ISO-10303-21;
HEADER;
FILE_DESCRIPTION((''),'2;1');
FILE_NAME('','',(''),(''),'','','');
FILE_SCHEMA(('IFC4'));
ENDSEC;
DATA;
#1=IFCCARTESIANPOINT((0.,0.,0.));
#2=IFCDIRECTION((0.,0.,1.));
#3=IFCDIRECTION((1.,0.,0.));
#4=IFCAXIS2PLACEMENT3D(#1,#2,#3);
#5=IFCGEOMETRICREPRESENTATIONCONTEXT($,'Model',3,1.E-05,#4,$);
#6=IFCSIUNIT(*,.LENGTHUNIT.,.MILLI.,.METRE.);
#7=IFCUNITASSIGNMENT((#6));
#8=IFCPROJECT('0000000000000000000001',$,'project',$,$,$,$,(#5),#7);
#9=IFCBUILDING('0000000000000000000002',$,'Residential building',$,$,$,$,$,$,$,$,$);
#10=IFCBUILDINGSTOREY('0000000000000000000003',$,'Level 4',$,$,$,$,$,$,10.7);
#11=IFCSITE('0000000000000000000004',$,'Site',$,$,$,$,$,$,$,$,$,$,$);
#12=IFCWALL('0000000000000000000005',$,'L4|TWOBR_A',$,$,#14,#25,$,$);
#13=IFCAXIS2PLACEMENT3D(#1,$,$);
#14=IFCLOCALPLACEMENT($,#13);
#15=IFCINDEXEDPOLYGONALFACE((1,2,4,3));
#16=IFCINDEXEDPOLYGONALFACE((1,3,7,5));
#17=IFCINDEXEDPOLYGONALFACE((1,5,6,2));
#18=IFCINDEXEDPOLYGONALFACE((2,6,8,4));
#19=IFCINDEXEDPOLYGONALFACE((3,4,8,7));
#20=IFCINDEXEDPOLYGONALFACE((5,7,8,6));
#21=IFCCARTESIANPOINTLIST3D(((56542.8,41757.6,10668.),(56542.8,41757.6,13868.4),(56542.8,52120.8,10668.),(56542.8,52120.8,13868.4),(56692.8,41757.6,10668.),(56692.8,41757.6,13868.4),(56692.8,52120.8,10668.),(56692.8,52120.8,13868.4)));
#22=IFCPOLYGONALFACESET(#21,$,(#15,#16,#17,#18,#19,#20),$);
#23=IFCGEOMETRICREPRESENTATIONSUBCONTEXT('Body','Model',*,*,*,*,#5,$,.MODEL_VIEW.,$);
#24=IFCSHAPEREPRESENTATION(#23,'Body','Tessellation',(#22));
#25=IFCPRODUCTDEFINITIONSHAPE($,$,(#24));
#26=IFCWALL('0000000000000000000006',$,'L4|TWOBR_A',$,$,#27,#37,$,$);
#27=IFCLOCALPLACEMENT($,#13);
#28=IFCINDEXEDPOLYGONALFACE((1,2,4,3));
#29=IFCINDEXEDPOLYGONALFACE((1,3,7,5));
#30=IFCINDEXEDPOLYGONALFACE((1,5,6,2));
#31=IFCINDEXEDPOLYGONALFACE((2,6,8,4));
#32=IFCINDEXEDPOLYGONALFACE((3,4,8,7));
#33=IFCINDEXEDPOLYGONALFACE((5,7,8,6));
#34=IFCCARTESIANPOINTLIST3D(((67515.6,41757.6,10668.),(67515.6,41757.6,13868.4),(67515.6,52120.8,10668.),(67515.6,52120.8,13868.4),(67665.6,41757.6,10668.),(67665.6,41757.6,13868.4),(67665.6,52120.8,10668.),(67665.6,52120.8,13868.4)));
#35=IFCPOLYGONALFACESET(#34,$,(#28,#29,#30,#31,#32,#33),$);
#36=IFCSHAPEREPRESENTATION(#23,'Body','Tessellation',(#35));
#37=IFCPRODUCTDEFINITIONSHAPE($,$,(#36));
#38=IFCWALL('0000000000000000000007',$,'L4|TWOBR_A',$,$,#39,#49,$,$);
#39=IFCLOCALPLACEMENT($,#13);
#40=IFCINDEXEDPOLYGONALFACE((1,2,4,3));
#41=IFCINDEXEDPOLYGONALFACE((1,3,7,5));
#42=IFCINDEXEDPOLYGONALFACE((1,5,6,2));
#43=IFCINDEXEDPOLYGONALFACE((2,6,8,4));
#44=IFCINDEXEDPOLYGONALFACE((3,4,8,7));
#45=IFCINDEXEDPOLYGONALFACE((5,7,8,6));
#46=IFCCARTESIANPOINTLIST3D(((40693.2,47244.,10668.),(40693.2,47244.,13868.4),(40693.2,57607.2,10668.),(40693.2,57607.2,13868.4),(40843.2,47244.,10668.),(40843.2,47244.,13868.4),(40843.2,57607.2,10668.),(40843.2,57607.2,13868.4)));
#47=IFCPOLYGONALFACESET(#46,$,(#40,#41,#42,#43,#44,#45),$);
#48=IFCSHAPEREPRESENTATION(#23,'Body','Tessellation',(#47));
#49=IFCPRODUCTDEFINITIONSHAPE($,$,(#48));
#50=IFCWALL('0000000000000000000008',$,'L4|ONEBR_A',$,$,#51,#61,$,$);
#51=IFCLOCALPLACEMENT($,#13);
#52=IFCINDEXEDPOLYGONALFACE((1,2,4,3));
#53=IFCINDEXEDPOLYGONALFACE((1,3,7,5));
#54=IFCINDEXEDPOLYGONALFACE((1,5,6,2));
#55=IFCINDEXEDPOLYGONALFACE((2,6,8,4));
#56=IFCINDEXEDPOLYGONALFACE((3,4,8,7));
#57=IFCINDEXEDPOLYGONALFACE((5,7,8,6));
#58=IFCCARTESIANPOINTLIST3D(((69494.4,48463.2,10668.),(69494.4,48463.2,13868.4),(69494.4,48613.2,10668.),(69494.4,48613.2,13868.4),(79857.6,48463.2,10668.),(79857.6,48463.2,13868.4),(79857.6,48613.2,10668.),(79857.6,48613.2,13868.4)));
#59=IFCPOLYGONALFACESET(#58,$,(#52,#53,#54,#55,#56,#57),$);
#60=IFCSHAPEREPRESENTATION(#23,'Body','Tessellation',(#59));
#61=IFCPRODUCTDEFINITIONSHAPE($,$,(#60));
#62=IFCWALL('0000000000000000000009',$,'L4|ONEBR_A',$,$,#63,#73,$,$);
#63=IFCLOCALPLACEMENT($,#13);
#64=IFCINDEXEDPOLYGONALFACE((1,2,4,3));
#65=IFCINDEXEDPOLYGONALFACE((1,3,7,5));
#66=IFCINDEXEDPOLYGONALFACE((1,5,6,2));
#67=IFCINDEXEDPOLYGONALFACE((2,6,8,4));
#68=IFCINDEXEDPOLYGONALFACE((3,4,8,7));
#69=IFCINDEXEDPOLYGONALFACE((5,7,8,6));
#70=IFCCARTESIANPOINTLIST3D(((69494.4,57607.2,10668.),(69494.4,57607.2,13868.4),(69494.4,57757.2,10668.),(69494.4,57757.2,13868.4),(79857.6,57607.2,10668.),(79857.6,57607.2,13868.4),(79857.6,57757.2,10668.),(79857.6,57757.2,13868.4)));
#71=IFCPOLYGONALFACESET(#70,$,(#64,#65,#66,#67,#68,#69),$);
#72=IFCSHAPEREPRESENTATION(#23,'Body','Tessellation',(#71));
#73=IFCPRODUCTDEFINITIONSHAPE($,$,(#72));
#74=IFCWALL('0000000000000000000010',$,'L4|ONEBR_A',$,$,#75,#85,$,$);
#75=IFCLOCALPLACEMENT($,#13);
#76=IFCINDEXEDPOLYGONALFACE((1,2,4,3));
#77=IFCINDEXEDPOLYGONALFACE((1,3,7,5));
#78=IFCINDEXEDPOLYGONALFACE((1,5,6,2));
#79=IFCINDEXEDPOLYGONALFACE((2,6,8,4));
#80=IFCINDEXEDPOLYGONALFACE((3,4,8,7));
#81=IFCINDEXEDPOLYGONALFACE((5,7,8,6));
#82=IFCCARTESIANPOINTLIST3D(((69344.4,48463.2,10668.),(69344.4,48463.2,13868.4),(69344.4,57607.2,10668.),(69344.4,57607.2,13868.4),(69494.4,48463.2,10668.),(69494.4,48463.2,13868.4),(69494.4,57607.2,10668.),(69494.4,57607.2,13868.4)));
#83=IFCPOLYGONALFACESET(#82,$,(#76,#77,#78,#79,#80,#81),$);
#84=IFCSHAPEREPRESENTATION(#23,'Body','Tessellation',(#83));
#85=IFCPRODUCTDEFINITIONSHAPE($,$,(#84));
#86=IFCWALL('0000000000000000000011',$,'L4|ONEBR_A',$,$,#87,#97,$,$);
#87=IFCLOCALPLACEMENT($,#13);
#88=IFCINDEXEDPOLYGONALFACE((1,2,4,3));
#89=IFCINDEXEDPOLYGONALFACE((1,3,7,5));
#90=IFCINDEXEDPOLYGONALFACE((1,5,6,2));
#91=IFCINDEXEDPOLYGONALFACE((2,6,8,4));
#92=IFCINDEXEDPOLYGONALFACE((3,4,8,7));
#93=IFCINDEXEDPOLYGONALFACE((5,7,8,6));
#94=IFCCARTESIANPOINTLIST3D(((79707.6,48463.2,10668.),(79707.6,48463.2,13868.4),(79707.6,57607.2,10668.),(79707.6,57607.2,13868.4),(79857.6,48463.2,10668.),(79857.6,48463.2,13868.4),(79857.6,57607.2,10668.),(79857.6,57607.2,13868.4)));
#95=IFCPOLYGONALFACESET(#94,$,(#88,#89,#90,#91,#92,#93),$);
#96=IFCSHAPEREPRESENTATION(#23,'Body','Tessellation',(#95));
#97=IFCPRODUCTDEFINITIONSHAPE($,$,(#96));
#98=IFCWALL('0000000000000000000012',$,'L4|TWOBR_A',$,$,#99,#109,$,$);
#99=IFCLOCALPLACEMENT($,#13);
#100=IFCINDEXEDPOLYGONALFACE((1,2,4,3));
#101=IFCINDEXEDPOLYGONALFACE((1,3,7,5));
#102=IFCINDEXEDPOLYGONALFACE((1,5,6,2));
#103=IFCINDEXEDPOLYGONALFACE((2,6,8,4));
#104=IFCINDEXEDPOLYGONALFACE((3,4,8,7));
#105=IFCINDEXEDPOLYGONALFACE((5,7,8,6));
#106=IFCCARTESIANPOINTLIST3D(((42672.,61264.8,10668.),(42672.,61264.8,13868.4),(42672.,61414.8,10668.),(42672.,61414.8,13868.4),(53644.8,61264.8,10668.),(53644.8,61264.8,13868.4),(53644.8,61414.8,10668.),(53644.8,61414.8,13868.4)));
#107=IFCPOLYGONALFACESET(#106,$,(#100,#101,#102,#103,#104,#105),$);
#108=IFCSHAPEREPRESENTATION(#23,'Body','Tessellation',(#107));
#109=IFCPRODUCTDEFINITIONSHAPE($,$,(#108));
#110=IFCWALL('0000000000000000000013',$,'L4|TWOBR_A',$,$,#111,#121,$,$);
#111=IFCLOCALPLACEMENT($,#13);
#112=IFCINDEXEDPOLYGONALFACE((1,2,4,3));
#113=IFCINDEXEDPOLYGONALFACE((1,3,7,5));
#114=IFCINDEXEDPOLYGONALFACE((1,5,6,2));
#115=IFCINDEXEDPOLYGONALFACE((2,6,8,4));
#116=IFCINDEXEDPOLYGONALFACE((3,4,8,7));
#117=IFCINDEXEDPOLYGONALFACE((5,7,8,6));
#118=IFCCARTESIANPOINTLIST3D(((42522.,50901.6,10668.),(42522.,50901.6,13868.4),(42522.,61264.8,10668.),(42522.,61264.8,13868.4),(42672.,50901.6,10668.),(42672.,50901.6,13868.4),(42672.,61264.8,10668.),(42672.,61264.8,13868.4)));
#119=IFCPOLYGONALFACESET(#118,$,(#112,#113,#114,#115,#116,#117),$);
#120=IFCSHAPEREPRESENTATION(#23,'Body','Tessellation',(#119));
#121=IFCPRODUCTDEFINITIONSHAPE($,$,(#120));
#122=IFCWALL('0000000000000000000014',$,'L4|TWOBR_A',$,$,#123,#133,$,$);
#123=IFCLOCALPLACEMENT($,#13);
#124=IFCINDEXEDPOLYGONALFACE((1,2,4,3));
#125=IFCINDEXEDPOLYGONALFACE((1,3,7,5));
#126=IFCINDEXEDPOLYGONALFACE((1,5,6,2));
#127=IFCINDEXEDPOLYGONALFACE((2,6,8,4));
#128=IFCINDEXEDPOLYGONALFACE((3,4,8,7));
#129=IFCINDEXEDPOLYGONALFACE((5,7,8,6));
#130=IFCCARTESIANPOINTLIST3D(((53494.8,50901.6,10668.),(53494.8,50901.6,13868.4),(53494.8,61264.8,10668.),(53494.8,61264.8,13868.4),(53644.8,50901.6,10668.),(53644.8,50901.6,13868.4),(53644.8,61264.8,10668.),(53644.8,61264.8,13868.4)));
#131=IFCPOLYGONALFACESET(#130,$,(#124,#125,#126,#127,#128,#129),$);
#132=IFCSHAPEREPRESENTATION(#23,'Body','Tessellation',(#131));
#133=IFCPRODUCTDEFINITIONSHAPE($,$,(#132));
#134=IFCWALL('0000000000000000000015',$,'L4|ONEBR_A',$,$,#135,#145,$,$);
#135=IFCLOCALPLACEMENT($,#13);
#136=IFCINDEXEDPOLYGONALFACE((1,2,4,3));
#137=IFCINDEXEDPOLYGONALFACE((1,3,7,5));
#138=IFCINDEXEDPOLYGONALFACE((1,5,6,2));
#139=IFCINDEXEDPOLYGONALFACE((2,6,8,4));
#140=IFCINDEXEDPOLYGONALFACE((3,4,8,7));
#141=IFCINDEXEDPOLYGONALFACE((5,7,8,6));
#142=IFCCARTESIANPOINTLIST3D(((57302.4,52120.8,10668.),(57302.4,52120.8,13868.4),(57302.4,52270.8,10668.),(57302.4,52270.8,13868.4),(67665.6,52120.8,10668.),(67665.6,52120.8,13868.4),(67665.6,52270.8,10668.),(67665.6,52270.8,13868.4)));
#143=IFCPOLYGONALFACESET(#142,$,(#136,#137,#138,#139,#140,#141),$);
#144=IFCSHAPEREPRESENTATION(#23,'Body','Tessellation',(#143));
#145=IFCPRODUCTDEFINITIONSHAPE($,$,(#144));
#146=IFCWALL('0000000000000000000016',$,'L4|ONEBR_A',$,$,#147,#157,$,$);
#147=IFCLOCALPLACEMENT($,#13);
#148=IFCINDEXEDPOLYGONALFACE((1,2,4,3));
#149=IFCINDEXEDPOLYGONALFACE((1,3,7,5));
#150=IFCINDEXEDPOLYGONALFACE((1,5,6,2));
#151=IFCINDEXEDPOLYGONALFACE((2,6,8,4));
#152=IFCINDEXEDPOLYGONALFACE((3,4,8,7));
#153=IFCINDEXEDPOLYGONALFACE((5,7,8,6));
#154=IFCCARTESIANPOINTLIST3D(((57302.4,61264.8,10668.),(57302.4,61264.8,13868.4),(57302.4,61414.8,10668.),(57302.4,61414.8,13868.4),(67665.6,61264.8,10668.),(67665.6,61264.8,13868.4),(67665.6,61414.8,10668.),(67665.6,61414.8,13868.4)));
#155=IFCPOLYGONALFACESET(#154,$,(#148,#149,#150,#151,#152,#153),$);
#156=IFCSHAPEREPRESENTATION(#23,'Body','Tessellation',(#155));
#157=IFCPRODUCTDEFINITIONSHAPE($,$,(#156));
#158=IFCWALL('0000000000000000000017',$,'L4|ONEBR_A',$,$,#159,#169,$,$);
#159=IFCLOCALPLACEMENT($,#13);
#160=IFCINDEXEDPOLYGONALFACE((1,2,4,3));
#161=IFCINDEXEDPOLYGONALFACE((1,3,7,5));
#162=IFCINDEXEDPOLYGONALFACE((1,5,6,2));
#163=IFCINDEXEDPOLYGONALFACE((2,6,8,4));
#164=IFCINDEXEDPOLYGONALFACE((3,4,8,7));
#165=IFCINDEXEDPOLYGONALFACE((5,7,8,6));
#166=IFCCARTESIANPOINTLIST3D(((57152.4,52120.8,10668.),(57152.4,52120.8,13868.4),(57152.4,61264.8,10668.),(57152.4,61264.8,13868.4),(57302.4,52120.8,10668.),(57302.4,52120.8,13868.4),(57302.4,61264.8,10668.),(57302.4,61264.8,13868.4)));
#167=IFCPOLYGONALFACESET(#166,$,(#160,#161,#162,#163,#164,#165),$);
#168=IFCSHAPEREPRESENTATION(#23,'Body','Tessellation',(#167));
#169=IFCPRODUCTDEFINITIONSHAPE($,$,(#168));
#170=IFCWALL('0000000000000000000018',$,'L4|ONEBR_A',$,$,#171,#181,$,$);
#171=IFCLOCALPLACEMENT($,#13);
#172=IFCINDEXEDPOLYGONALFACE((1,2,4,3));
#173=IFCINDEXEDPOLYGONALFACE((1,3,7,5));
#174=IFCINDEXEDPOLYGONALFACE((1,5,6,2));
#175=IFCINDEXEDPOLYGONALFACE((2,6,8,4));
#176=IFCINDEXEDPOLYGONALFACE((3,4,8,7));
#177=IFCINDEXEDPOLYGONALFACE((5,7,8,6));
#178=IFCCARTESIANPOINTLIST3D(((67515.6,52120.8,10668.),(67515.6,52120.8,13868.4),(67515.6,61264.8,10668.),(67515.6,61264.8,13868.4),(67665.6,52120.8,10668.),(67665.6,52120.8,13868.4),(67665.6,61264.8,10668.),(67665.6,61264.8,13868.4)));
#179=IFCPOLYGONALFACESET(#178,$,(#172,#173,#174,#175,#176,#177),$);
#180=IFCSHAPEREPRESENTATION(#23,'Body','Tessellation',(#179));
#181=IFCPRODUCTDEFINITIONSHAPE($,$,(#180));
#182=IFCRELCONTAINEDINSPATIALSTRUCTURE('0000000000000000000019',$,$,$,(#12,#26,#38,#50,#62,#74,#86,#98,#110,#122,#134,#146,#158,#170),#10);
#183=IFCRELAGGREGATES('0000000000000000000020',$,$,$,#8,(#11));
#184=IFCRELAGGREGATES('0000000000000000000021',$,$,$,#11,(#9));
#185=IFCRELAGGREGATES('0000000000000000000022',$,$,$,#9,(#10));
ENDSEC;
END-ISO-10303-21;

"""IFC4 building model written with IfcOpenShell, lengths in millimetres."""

from ifc_helpers import new_model, si_unit, frame, origin_with_axes, place, context, subcontext, project, spatial, indexed_curve, outline, extrude, element, save


model = new_model("IFC4")

# Units and contexts
model_context = context("Model", 3, precision=1e-05, world=origin_with_axes())
body_context = subcontext(model_context, "Body", "Model", "MODEL_VIEW")
ifc_project = project(units=[si_unit("LENGTHUNIT", "METRE", prefix="MILLI")], contexts=[model_context])

# Site, building, storey
site = spatial("IfcSite", under=ifc_project, Name="Site")
building = spatial("IfcBuilding", under=site, Name="Residential building")
storey = spatial("IfcBuildingStorey", under=building, Name="Level 4", Elevation=10.7)

# Walls
for number, where, z_axis, x_axis, name in (
    (1, (56692.8, 41757.6, 10668.0), (0.0, 0.0, 1.0), (0.0, 1.0, 0.0), "L4|TWOBR_A"),
    (2, (67665.6, 41757.6, 10668.0), (0.0, 0.0, 1.0), (0.0, 1.0, 0.0), "L4|TWOBR_A"),
    (3, (40843.2, 47244.0, 10668.0), (0.0, 0.0, 1.0), (0.0, 1.0, 0.0), "L4|TWOBR_A"),
    (4, (69494.4, 48463.2, 10668.0), (0.0, 0.0, 1.0), (1.0, 0.0, 0.0), "L4|ONEBR_A"),
    (5, (69494.4, 57607.2, 10668.0), (0.0, 0.0, 1.0), (1.0, 0.0, 0.0), "L4|ONEBR_A"),
):
    element("IfcWall", number, at=place(None, frame(where, z_axis=z_axis, x_axis=x_axis)), inside=storey, Name=name, context=body_context, shape_type="SweptSolid", body=[
        extrude(outline(indexed_curve([(0.0, 0.0), (0.0, 150.0), (10363.2, 150.0), (10363.2, 0.0), (0.0, 0.0)], self_intersect=False)), origin_with_axes(), (0.0, 0.0, 1.0), 3200.4),
    ])
for number, where, z_axis, x_axis, name in (
    (6, (69494.4, 48463.2, 10668.0), (0.0, 0.0, 1.0), (0.0, 1.0, 0.0), "L4|ONEBR_A"),
    (7, (79857.6, 48463.2, 10668.0), (0.0, 0.0, 1.0), (0.0, 1.0, 0.0), "L4|ONEBR_A"),
):
    element("IfcWall", number, at=place(None, frame(where, z_axis=z_axis, x_axis=x_axis)), inside=storey, Name=name, context=body_context, shape_type="SweptSolid", body=[
        extrude(outline(indexed_curve([(0.0, 0.0), (0.0, 150.0), (9144.0, 150.0), (9144.0, 0.0), (0.0, 0.0)], self_intersect=False)), origin_with_axes(), (0.0, 0.0, 1.0), 3200.4),
    ])
for number, where, z_axis, x_axis, name in (
    (8, (42672.0, 61264.8, 10668.0), (0.0, 0.0, 1.0), (1.0, 0.0, 0.0), "L4|TWOBR_A"),
):
    element("IfcWall", number, at=place(None, frame(where, z_axis=z_axis, x_axis=x_axis)), inside=storey, Name=name, context=body_context, shape_type="SweptSolid", body=[
        extrude(outline(indexed_curve([(0.0, 0.0), (0.0, 150.0), (10972.8, 150.0), (10972.8, 0.0), (0.0, 0.0)], self_intersect=False)), origin_with_axes(), (0.0, 0.0, 1.0), 3200.4),
    ])
for number, where, z_axis, x_axis, name in (
    (9, (42672.0, 50901.6, 10668.0), (0.0, 0.0, 1.0), (0.0, 1.0, 0.0), "L4|TWOBR_A"),
    (10, (53644.8, 50901.6, 10668.0), (0.0, 0.0, 1.0), (0.0, 1.0, 0.0), "L4|TWOBR_A"),
    (11, (57302.4, 52120.8, 10668.0), (0.0, 0.0, 1.0), (1.0, 0.0, 0.0), "L4|ONEBR_A"),
    (12, (57302.4, 61264.8, 10668.0), (0.0, 0.0, 1.0), (1.0, 0.0, 0.0), "L4|ONEBR_A"),
):
    element("IfcWall", number, at=place(None, frame(where, z_axis=z_axis, x_axis=x_axis)), inside=storey, Name=name, context=body_context, shape_type="SweptSolid", body=[
        extrude(outline(indexed_curve([(0.0, 0.0), (0.0, 150.0), (10363.2, 150.0), (10363.2, 0.0), (0.0, 0.0)], self_intersect=False)), origin_with_axes(), (0.0, 0.0, 1.0), 3200.4),
    ])
for number, where, z_axis, x_axis, name in (
    (13, (57302.4, 52120.8, 10668.0), (0.0, 0.0, 1.0), (0.0, 1.0, 0.0), "L4|ONEBR_A"),
    (14, (67665.6, 52120.8, 10668.0), (0.0, 0.0, 1.0), (0.0, 1.0, 0.0), "L4|ONEBR_A"),
):
    element("IfcWall", number, at=place(None, frame(where, z_axis=z_axis, x_axis=x_axis)), inside=storey, Name=name, context=body_context, shape_type="SweptSolid", body=[
        extrude(outline(indexed_curve([(0.0, 0.0), (0.0, 150.0), (9144.0, 150.0), (9144.0, 0.0), (0.0, 0.0)], self_intersect=False)), origin_with_axes(), (0.0, 0.0, 1.0), 3200.4),
    ])

save(model, "model.ifc")
